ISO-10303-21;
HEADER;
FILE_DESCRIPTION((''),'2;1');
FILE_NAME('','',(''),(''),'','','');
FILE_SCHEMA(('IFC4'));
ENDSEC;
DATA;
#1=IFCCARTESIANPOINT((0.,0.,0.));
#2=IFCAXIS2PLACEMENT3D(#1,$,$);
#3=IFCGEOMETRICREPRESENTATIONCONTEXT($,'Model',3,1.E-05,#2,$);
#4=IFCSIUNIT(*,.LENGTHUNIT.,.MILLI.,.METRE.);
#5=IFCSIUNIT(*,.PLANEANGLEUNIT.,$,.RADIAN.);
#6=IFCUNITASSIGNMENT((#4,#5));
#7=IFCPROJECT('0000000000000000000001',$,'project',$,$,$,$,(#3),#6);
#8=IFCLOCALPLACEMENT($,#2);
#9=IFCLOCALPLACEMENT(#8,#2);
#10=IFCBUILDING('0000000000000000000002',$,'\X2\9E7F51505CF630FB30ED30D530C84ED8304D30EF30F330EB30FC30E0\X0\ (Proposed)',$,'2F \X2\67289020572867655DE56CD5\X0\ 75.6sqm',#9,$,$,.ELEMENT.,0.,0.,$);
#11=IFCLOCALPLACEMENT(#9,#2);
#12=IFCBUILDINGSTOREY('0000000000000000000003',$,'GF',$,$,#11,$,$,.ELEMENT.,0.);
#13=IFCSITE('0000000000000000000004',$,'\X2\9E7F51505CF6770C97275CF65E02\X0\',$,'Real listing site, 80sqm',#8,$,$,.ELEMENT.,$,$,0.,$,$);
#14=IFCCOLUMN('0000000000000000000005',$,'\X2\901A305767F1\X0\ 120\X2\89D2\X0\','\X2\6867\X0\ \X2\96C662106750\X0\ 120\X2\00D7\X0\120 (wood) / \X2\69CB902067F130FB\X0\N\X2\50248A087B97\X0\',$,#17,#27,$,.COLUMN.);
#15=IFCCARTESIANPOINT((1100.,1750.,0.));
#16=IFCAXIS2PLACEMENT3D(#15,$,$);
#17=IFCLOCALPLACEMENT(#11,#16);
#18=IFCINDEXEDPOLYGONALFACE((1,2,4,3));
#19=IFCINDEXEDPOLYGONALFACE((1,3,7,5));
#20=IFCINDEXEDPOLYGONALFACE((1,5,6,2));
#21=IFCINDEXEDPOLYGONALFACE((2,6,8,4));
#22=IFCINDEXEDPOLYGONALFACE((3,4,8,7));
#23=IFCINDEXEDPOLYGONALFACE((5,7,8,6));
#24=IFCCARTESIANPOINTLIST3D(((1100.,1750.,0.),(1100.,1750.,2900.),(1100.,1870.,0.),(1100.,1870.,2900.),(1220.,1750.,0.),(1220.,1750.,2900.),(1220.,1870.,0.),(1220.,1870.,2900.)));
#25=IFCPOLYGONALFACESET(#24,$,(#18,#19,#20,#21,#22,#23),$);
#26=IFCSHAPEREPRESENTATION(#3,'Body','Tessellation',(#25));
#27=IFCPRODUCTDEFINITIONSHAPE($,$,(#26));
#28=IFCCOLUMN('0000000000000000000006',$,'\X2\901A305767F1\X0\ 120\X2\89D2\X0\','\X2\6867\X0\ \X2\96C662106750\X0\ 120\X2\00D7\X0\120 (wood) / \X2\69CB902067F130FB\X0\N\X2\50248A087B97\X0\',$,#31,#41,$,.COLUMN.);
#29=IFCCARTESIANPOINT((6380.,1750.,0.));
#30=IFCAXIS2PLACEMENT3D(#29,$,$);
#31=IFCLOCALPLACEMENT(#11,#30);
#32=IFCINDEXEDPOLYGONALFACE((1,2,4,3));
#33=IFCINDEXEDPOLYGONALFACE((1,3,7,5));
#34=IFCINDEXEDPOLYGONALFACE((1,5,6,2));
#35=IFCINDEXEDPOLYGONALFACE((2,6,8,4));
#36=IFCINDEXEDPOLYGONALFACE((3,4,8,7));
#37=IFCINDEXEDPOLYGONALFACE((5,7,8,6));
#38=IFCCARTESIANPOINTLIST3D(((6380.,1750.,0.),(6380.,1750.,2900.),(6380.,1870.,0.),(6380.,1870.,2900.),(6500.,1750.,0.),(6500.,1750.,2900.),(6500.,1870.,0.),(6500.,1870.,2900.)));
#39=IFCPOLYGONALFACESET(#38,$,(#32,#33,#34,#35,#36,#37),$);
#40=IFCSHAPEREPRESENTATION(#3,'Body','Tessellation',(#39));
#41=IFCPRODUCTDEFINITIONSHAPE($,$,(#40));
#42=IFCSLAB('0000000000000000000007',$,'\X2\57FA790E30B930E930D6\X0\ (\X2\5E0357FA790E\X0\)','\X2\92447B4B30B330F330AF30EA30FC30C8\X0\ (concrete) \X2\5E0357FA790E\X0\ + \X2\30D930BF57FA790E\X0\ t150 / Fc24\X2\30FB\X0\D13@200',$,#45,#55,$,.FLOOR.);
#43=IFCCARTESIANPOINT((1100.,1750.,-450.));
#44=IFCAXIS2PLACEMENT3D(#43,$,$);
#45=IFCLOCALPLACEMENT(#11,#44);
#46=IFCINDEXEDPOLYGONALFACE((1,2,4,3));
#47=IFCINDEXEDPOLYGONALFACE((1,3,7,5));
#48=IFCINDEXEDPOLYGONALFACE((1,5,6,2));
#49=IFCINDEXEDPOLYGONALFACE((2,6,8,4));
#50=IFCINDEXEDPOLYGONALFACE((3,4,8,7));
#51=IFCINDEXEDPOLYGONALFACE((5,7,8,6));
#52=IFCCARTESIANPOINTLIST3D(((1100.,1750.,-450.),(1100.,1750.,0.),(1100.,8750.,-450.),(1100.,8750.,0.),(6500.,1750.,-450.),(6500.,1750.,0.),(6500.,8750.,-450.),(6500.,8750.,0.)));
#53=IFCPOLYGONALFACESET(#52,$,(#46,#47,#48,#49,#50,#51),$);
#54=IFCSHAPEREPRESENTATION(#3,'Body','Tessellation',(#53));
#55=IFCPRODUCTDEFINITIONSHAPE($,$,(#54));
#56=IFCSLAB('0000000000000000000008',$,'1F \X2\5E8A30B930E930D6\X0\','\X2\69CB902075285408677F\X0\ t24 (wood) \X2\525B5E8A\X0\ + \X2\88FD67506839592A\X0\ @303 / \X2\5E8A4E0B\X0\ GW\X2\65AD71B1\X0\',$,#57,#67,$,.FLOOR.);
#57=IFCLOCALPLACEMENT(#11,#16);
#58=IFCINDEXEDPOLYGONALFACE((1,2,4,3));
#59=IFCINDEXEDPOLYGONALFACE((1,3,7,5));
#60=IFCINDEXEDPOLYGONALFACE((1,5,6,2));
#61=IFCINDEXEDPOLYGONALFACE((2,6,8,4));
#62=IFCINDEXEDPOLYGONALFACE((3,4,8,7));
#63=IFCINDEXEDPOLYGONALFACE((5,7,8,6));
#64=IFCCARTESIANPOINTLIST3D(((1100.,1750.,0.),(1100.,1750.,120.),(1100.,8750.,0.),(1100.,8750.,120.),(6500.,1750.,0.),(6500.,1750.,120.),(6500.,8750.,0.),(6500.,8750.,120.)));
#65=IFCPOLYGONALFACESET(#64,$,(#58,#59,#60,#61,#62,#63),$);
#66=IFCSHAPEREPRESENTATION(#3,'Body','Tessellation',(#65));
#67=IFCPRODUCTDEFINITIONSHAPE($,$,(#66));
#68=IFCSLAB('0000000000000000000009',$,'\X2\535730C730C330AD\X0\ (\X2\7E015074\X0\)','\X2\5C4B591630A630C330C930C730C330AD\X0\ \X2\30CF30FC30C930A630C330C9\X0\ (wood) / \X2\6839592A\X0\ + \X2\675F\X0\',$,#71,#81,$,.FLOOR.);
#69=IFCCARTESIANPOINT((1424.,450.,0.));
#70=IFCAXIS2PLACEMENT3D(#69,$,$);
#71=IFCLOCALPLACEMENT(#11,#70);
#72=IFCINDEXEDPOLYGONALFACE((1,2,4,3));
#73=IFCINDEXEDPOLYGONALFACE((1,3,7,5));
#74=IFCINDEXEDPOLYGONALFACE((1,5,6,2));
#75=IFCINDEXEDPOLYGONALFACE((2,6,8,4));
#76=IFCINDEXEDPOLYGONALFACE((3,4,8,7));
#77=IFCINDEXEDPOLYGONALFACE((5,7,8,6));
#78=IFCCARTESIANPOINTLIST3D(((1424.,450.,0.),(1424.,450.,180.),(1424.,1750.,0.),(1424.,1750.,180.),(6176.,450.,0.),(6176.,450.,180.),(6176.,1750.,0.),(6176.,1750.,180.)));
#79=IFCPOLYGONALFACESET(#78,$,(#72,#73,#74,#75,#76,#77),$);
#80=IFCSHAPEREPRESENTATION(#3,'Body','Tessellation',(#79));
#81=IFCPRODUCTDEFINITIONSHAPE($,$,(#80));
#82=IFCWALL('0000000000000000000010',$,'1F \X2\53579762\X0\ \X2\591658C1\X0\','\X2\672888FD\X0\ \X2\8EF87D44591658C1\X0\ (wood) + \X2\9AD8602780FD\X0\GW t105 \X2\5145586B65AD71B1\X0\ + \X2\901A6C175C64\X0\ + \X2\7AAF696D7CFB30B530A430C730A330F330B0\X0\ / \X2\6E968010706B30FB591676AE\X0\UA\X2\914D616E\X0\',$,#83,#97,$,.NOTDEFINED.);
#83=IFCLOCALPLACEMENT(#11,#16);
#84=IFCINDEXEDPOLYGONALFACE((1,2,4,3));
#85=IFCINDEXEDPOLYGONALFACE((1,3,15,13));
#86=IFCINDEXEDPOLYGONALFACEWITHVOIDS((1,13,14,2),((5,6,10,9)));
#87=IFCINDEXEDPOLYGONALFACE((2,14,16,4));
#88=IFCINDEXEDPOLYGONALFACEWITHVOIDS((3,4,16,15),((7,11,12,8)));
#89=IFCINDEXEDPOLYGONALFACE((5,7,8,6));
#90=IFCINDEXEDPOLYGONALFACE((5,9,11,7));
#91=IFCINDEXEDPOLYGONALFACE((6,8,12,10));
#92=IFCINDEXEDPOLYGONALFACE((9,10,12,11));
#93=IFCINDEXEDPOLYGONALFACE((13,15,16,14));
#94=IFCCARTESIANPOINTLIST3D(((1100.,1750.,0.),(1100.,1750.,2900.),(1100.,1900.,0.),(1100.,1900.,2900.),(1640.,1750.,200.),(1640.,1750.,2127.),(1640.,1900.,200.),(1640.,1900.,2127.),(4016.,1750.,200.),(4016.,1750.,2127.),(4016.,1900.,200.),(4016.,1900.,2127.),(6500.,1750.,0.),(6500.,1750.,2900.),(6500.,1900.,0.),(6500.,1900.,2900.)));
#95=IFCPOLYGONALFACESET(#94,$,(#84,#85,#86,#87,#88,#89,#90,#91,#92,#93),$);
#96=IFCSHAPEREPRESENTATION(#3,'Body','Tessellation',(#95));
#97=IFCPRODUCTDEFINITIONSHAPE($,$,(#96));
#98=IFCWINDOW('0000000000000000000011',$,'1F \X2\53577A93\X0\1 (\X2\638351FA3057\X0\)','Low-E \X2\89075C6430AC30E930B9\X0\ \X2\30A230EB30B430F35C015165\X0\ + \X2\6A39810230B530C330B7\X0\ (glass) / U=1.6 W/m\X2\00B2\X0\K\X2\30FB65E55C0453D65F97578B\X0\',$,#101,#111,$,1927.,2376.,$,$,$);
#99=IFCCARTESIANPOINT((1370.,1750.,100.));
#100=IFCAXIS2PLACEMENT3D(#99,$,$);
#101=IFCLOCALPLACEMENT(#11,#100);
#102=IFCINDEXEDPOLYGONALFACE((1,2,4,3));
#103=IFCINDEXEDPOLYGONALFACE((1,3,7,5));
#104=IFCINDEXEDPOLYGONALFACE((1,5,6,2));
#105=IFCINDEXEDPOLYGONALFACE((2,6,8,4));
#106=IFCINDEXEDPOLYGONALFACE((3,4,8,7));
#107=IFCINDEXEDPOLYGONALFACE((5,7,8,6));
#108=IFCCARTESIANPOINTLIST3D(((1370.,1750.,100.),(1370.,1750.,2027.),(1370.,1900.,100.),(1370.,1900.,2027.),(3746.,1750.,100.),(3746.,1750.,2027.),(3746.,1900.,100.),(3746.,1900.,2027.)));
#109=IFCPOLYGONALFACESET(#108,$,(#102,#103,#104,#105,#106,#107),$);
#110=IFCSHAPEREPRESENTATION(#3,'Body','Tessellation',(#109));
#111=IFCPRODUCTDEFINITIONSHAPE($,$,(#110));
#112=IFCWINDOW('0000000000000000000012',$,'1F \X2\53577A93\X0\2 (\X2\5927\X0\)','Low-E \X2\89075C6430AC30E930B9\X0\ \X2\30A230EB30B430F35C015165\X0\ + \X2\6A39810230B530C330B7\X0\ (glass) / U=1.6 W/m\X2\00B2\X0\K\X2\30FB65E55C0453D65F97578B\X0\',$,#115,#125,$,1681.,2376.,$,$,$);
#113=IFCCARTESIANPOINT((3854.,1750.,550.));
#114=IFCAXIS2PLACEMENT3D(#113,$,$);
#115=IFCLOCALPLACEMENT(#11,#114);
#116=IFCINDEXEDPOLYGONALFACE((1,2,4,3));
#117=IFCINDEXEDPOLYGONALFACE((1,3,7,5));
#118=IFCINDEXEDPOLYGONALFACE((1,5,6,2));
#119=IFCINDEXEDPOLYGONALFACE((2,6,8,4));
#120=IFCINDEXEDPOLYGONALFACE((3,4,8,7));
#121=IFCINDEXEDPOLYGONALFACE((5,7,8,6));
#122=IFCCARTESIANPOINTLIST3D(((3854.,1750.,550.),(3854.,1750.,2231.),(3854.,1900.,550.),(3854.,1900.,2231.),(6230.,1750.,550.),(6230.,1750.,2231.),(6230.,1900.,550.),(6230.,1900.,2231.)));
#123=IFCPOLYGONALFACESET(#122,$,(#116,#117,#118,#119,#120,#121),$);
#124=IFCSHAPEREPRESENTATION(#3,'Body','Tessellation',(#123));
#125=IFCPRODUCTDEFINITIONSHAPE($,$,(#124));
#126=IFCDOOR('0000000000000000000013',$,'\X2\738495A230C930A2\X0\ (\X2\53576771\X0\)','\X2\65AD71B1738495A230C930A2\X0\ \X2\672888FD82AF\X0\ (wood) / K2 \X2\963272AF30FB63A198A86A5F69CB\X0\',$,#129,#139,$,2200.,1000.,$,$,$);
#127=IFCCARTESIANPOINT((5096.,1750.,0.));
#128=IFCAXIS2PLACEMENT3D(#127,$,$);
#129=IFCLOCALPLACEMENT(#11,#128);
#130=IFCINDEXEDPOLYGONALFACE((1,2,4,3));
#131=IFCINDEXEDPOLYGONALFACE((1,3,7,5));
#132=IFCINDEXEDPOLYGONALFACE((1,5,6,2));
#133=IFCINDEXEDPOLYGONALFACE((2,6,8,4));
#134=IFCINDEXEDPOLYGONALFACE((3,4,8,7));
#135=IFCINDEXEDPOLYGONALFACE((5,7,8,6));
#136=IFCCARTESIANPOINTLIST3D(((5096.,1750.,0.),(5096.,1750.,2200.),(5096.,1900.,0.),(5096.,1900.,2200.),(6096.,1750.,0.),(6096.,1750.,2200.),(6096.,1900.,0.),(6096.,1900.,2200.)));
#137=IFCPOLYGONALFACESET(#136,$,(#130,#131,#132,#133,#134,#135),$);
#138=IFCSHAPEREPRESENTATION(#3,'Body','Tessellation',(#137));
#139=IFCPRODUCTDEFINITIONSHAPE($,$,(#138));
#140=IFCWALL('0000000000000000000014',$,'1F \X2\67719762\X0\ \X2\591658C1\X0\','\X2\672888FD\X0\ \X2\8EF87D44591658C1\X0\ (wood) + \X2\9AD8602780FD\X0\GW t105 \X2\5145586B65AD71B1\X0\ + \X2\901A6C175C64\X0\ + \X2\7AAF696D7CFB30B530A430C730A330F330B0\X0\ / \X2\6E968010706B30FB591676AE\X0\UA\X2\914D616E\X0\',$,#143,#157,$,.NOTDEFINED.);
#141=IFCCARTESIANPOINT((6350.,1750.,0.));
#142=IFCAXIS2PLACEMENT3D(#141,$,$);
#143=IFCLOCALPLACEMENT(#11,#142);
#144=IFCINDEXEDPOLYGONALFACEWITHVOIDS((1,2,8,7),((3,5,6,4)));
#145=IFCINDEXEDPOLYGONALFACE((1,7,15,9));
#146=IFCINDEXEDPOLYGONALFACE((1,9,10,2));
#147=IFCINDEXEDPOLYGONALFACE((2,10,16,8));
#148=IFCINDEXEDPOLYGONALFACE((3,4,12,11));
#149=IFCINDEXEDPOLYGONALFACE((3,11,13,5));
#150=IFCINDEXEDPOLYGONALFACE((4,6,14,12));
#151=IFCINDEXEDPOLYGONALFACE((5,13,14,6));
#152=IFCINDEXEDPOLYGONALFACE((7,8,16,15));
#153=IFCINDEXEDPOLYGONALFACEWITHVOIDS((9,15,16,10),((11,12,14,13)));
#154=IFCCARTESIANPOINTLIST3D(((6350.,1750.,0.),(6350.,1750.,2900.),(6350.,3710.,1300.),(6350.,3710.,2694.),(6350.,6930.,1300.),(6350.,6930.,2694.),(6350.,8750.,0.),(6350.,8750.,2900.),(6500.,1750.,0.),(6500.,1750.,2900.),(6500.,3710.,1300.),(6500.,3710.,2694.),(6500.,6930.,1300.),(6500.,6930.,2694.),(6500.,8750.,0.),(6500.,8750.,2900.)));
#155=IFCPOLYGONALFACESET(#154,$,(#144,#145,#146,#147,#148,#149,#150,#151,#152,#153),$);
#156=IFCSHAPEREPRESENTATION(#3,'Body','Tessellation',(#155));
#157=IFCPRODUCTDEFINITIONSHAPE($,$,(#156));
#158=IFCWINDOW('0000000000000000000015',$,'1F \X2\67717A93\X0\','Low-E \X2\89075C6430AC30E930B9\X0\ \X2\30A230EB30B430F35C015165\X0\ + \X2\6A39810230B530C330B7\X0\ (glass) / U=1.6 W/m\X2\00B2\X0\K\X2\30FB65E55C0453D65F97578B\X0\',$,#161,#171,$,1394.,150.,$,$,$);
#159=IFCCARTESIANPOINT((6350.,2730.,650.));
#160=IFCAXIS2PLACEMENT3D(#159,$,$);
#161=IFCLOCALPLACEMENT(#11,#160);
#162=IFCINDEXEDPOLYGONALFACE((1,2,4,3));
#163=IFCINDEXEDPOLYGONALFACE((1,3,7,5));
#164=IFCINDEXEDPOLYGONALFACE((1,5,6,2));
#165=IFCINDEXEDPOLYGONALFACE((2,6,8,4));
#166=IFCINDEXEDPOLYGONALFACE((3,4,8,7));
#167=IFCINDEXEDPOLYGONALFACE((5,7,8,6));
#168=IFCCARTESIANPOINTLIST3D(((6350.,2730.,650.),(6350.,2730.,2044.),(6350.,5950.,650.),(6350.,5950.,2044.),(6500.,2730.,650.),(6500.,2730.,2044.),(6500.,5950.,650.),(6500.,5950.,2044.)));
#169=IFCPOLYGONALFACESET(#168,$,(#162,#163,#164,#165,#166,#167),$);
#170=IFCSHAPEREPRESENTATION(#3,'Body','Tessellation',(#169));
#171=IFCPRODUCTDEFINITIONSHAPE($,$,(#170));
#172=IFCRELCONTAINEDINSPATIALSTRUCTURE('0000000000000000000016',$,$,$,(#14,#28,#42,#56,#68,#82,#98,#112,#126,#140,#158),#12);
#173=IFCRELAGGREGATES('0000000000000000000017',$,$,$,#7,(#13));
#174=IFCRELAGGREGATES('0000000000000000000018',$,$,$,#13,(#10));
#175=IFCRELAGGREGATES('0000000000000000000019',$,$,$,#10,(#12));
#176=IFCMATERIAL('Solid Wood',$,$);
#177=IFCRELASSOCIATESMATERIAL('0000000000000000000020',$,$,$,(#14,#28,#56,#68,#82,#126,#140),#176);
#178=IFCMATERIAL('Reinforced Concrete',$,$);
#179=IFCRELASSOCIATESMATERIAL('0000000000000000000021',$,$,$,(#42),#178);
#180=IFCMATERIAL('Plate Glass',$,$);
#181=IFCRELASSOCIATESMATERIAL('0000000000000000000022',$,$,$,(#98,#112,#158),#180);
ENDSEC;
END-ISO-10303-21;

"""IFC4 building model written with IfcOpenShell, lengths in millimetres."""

from ifc_helpers import new_model, si_unit, frame, frame_2d, origin, place, context, project, spatial, rectangle, extrude, material, element, fill, save


model = new_model("IFC4")

# Units and contexts
model_context = context("Model", 3, precision=1e-05, world=origin())
ifc_project = project(units=[si_unit("LENGTHUNIT", "METRE", prefix="MILLI"), si_unit("PLANEANGLEUNIT", "RADIAN")], contexts=[model_context])

# Site, building, storey
site_placement = place(None, origin())
site = spatial("IfcSite", under=ifc_project, at=site_placement, Name="鹿児島県霧島市", ObjectType="Real listing site, 80sqm", CompositionType="ELEMENT", RefElevation=0.0)
building_placement = place(site_placement, origin())
building = spatial("IfcBuilding", under=site, at=building_placement, Name="鹿児島・ロフト付きワンルーム (Proposed)", ObjectType="2F 木造在来工法 75.6sqm", CompositionType="ELEMENT", ElevationOfRefHeight=0.0, ElevationOfTerrain=0.0)
storey_placement = place(building_placement, origin())
storey = spatial("IfcBuildingStorey", under=building, at=storey_placement, Name="GF", CompositionType="ELEMENT", Elevation=0.0)

# Columns
ifc_material_1 = material(Name="Solid Wood")
column_1_placement = place(storey_placement, frame((1100.0, 1750.0, 0.0)))
element("IfcColumn", 1, at=column_1_placement, inside=storey, material=ifc_material_1, Name="通し柱 120角", Description="桧 集成材 120×120 (wood) / 構造柱・N値計算", PredefinedType="COLUMN", context=model_context, shape_type="SweptSolid", body=[
    extrude(rectangle(XDim=120.0, YDim=120.0, at=frame_2d((60.0, 60.0))), frame((1100.0, 1750.0, 0.0)), (0.0, 0.0, 1.0), 2900.0),
])
column_2_placement = place(storey_placement, frame((6380.0, 1750.0, 0.0)))
element("IfcColumn", 2, at=column_2_placement, inside=storey, material=ifc_material_1, Name="通し柱 120角", Description="桧 集成材 120×120 (wood) / 構造柱・N値計算", PredefinedType="COLUMN", context=model_context, shape_type="SweptSolid", body=[
    extrude(rectangle(XDim=120.0, YDim=120.0, at=frame_2d((60.0, 60.0))), frame((6380.0, 1750.0, 0.0)), (0.0, 0.0, 1.0), 2900.0),
])

# Slabs
ifc_material_2 = material(Name="Reinforced Concrete")
slab_1_placement = place(storey_placement, frame((1100.0, 1750.0, -450.0)))
element("IfcSlab", 3, at=slab_1_placement, inside=storey, material=ifc_material_2, Name="基礎スラブ (布基礎)", Description="鉄筋コンクリート (concrete) 布基礎 + ベタ基礎 t150 / Fc24・D13@200", PredefinedType="FLOOR", context=model_context, shape_type="SweptSolid", body=[
    extrude(rectangle(XDim=5400.0, YDim=7000.0, at=frame_2d((2700.0, 3500.0))), frame((1100.0, 1750.0, -450.0)), (0.0, 0.0, 1.0), 450.0),
])
slab_2_placement = place(storey_placement, frame((1100.0, 1750.0, 0.0)))
element("IfcSlab", 4, at=slab_2_placement, inside=storey, material=ifc_material_1, Name="1F 床スラブ", Description="構造用合板 t24 (wood) 剛床 + 製材根太 @303 / 床下 GW断熱", PredefinedType="FLOOR", context=model_context, shape_type="SweptSolid", body=[
    extrude(rectangle(XDim=5400.0, YDim=7000.0, at=frame_2d((2700.0, 3500.0))), frame((1100.0, 1750.0, 0.0)), (0.0, 0.0, 1.0), 120.0),
])
slab_3_placement = place(storey_placement, frame((1424.0, 450.0, 0.0)))
element("IfcSlab", 5, at=slab_3_placement, inside=storey, material=ifc_material_1, Name="南デッキ (縁側)", Description="屋外ウッドデッキ ハードウッド (wood) / 根太 + 束", PredefinedType="FLOOR", context=model_context, shape_type="SweptSolid", body=[
    extrude(rectangle(XDim=4752.0, YDim=1300.0, at=frame_2d((2376.0, 650.0))), frame((1424.0, 450.0, 0.0)), (0.0, 0.0, 1.0), 180.0),
])

# Wall, openings, windows, door
wall_1_placement = place(storey_placement, frame((1100.0, 1750.0, 0.0)))
wall_1 = element("IfcWall", 6, at=wall_1_placement, inside=storey, material=ifc_material_1, Name="1F 南面 外壁", Description="木製 軸組外壁 (wood) + 高性能GW t105 充填断熱 + 通気層 + 窯業系サイディング / 準耐火・外皮UA配慮", PredefinedType="NOTDEFINED", context=model_context, shape_type="SweptSolid", body=[
    extrude(rectangle(XDim=5400.0, YDim=150.0, at=frame_2d((2700.0, 75.0))), frame((1100.0, 1750.0, 0.0)), (0.0, 0.0, 1.0), 2900.0),
])
opening_1_placement = place(storey_placement, frame((1370.0, 1750.0, 100.0)))
opening_1 = element("IfcOpeningElement", 7, at=opening_1_placement, cuts=wall_1, PredefinedType="NOTDEFINED", context=model_context, shape_type="SweptSolid", body=[
    extrude(rectangle(XDim=2376.0, YDim=150.0, at=frame_2d((1188.0, 75.0))), frame((1370.0, 1750.0, 100.0)), (0.0, 0.0, 1.0), 1927.0),
])
opening_2_placement = place(storey_placement, frame((3854.0, 1750.0, 550.0)))
opening_2 = element("IfcOpeningElement", 8, at=opening_2_placement, cuts=wall_1, PredefinedType="NOTDEFINED", context=model_context, shape_type="SweptSolid", body=[
    extrude(rectangle(XDim=2376.0, YDim=150.0, at=frame_2d((1188.0, 75.0))), frame((3854.0, 1750.0, 550.0)), (0.0, 0.0, 1.0), 1681.0),
])
opening_3_placement = place(storey_placement, frame((5096.0, 1750.0, 0.0)))
opening_3 = element("IfcOpeningElement", 9, at=opening_3_placement, cuts=wall_1, PredefinedType="NOTDEFINED", context=model_context, shape_type="SweptSolid", body=[
    extrude(rectangle(XDim=1000.0, YDim=150.0, at=frame_2d((500.0, 75.0))), frame((5096.0, 1750.0, 0.0)), (0.0, 0.0, 1.0), 2200.0),
])
ifc_material_3 = material(Name="Plate Glass")
window_1_placement = place(storey_placement, frame((1370.0, 1750.0, 100.0)))
window_1 = element("IfcWindow", 10, at=window_1_placement, inside=storey, material=ifc_material_3, Name="1F 南窓1 (掃出し)", Description="Low-E 複層ガラス アルゴン封入 + 樹脂サッシ (glass) / U=1.6 W/m²K・日射取得型", OverallHeight=1927.0, OverallWidth=2376.0, context=model_context, shape_type="SweptSolid", body=[
    extrude(rectangle(XDim=2376.0, YDim=150.0, at=frame_2d((1188.0, 75.0))), frame((1370.0, 1750.0, 100.0)), (0.0, 0.0, 1.0), 1927.0),
])
fill(opening_1, window_1)
window_2_placement = place(storey_placement, frame((3854.0, 1750.0, 550.0)))
window_2 = element("IfcWindow", 11, at=window_2_placement, inside=storey, material=ifc_material_3, Name="1F 南窓2 (大)", Description="Low-E 複層ガラス アルゴン封入 + 樹脂サッシ (glass) / U=1.6 W/m²K・日射取得型", OverallHeight=1681.0, OverallWidth=2376.0, context=model_context, shape_type="SweptSolid", body=[
    extrude(rectangle(XDim=2376.0, YDim=150.0, at=frame_2d((1188.0, 75.0))), frame((3854.0, 1750.0, 550.0)), (0.0, 0.0, 1.0), 1681.0),
])
fill(opening_2, window_2)
door_placement = place(storey_placement, frame((5096.0, 1750.0, 0.0)))
door = element("IfcDoor", 12, at=door_placement, inside=storey, material=ifc_material_1, Name="玄関ドア (南東)", Description="断熱玄関ドア 木製芯 (wood) / K2 防犯・採風機構", OverallHeight=2200.0, OverallWidth=1000.0, context=model_context, shape_type="SweptSolid", body=[
    extrude(rectangle(XDim=1000.0, YDim=150.0, at=frame_2d((500.0, 75.0))), frame((5096.0, 1750.0, 0.0)), (0.0, 0.0, 1.0), 2200.0),
])
fill(opening_3, door)

# Wall, opening, window
wall_2_placement = place(storey_placement, frame((6350.0, 1750.0, 0.0)))
wall_2 = element("IfcWall", 13, at=wall_2_placement, inside=storey, material=ifc_material_1, Name="1F 東面 外壁", Description="木製 軸組外壁 (wood) + 高性能GW t105 充填断熱 + 通気層 + 窯業系サイディング / 準耐火・外皮UA配慮", PredefinedType="NOTDEFINED", context=model_context, shape_type="SweptSolid", body=[
    extrude(rectangle(XDim=150.0, YDim=7000.0, at=frame_2d((75.0, 3500.0))), frame((6350.0, 1750.0, 0.0)), (0.0, 0.0, 1.0), 2900.0),
])
opening_4_placement = place(storey_placement, frame((6350.0, 2730.0, 650.0)))
opening_4 = element("IfcOpeningElement", 14, at=opening_4_placement, cuts=wall_2, PredefinedType="NOTDEFINED", context=model_context, shape_type="SweptSolid", body=[
    extrude(rectangle(XDim=150.0, YDim=3220.0, at=frame_2d((75.0, 1610.0))), frame((6350.0, 2730.0, 650.0)), (0.0, 0.0, 1.0), 1394.0),
])
window_3_placement = place(storey_placement, frame((6350.0, 2730.0, 650.0)))
window_3 = element("IfcWindow", 15, at=window_3_placement, inside=storey, material=ifc_material_3, Name="1F 東窓", Description="Low-E 複層ガラス アルゴン封入 + 樹脂サッシ (glass) / U=1.6 W/m²K・日射取得型", OverallHeight=1394.0, OverallWidth=150.0, context=model_context, shape_type="SweptSolid", body=[
    extrude(rectangle(XDim=150.0, YDim=3220.0, at=frame_2d((75.0, 1610.0))), frame((6350.0, 2730.0, 650.0)), (0.0, 0.0, 1.0), 1394.0),
])
fill(opening_4, window_3)

save(model, "model.ifc")
